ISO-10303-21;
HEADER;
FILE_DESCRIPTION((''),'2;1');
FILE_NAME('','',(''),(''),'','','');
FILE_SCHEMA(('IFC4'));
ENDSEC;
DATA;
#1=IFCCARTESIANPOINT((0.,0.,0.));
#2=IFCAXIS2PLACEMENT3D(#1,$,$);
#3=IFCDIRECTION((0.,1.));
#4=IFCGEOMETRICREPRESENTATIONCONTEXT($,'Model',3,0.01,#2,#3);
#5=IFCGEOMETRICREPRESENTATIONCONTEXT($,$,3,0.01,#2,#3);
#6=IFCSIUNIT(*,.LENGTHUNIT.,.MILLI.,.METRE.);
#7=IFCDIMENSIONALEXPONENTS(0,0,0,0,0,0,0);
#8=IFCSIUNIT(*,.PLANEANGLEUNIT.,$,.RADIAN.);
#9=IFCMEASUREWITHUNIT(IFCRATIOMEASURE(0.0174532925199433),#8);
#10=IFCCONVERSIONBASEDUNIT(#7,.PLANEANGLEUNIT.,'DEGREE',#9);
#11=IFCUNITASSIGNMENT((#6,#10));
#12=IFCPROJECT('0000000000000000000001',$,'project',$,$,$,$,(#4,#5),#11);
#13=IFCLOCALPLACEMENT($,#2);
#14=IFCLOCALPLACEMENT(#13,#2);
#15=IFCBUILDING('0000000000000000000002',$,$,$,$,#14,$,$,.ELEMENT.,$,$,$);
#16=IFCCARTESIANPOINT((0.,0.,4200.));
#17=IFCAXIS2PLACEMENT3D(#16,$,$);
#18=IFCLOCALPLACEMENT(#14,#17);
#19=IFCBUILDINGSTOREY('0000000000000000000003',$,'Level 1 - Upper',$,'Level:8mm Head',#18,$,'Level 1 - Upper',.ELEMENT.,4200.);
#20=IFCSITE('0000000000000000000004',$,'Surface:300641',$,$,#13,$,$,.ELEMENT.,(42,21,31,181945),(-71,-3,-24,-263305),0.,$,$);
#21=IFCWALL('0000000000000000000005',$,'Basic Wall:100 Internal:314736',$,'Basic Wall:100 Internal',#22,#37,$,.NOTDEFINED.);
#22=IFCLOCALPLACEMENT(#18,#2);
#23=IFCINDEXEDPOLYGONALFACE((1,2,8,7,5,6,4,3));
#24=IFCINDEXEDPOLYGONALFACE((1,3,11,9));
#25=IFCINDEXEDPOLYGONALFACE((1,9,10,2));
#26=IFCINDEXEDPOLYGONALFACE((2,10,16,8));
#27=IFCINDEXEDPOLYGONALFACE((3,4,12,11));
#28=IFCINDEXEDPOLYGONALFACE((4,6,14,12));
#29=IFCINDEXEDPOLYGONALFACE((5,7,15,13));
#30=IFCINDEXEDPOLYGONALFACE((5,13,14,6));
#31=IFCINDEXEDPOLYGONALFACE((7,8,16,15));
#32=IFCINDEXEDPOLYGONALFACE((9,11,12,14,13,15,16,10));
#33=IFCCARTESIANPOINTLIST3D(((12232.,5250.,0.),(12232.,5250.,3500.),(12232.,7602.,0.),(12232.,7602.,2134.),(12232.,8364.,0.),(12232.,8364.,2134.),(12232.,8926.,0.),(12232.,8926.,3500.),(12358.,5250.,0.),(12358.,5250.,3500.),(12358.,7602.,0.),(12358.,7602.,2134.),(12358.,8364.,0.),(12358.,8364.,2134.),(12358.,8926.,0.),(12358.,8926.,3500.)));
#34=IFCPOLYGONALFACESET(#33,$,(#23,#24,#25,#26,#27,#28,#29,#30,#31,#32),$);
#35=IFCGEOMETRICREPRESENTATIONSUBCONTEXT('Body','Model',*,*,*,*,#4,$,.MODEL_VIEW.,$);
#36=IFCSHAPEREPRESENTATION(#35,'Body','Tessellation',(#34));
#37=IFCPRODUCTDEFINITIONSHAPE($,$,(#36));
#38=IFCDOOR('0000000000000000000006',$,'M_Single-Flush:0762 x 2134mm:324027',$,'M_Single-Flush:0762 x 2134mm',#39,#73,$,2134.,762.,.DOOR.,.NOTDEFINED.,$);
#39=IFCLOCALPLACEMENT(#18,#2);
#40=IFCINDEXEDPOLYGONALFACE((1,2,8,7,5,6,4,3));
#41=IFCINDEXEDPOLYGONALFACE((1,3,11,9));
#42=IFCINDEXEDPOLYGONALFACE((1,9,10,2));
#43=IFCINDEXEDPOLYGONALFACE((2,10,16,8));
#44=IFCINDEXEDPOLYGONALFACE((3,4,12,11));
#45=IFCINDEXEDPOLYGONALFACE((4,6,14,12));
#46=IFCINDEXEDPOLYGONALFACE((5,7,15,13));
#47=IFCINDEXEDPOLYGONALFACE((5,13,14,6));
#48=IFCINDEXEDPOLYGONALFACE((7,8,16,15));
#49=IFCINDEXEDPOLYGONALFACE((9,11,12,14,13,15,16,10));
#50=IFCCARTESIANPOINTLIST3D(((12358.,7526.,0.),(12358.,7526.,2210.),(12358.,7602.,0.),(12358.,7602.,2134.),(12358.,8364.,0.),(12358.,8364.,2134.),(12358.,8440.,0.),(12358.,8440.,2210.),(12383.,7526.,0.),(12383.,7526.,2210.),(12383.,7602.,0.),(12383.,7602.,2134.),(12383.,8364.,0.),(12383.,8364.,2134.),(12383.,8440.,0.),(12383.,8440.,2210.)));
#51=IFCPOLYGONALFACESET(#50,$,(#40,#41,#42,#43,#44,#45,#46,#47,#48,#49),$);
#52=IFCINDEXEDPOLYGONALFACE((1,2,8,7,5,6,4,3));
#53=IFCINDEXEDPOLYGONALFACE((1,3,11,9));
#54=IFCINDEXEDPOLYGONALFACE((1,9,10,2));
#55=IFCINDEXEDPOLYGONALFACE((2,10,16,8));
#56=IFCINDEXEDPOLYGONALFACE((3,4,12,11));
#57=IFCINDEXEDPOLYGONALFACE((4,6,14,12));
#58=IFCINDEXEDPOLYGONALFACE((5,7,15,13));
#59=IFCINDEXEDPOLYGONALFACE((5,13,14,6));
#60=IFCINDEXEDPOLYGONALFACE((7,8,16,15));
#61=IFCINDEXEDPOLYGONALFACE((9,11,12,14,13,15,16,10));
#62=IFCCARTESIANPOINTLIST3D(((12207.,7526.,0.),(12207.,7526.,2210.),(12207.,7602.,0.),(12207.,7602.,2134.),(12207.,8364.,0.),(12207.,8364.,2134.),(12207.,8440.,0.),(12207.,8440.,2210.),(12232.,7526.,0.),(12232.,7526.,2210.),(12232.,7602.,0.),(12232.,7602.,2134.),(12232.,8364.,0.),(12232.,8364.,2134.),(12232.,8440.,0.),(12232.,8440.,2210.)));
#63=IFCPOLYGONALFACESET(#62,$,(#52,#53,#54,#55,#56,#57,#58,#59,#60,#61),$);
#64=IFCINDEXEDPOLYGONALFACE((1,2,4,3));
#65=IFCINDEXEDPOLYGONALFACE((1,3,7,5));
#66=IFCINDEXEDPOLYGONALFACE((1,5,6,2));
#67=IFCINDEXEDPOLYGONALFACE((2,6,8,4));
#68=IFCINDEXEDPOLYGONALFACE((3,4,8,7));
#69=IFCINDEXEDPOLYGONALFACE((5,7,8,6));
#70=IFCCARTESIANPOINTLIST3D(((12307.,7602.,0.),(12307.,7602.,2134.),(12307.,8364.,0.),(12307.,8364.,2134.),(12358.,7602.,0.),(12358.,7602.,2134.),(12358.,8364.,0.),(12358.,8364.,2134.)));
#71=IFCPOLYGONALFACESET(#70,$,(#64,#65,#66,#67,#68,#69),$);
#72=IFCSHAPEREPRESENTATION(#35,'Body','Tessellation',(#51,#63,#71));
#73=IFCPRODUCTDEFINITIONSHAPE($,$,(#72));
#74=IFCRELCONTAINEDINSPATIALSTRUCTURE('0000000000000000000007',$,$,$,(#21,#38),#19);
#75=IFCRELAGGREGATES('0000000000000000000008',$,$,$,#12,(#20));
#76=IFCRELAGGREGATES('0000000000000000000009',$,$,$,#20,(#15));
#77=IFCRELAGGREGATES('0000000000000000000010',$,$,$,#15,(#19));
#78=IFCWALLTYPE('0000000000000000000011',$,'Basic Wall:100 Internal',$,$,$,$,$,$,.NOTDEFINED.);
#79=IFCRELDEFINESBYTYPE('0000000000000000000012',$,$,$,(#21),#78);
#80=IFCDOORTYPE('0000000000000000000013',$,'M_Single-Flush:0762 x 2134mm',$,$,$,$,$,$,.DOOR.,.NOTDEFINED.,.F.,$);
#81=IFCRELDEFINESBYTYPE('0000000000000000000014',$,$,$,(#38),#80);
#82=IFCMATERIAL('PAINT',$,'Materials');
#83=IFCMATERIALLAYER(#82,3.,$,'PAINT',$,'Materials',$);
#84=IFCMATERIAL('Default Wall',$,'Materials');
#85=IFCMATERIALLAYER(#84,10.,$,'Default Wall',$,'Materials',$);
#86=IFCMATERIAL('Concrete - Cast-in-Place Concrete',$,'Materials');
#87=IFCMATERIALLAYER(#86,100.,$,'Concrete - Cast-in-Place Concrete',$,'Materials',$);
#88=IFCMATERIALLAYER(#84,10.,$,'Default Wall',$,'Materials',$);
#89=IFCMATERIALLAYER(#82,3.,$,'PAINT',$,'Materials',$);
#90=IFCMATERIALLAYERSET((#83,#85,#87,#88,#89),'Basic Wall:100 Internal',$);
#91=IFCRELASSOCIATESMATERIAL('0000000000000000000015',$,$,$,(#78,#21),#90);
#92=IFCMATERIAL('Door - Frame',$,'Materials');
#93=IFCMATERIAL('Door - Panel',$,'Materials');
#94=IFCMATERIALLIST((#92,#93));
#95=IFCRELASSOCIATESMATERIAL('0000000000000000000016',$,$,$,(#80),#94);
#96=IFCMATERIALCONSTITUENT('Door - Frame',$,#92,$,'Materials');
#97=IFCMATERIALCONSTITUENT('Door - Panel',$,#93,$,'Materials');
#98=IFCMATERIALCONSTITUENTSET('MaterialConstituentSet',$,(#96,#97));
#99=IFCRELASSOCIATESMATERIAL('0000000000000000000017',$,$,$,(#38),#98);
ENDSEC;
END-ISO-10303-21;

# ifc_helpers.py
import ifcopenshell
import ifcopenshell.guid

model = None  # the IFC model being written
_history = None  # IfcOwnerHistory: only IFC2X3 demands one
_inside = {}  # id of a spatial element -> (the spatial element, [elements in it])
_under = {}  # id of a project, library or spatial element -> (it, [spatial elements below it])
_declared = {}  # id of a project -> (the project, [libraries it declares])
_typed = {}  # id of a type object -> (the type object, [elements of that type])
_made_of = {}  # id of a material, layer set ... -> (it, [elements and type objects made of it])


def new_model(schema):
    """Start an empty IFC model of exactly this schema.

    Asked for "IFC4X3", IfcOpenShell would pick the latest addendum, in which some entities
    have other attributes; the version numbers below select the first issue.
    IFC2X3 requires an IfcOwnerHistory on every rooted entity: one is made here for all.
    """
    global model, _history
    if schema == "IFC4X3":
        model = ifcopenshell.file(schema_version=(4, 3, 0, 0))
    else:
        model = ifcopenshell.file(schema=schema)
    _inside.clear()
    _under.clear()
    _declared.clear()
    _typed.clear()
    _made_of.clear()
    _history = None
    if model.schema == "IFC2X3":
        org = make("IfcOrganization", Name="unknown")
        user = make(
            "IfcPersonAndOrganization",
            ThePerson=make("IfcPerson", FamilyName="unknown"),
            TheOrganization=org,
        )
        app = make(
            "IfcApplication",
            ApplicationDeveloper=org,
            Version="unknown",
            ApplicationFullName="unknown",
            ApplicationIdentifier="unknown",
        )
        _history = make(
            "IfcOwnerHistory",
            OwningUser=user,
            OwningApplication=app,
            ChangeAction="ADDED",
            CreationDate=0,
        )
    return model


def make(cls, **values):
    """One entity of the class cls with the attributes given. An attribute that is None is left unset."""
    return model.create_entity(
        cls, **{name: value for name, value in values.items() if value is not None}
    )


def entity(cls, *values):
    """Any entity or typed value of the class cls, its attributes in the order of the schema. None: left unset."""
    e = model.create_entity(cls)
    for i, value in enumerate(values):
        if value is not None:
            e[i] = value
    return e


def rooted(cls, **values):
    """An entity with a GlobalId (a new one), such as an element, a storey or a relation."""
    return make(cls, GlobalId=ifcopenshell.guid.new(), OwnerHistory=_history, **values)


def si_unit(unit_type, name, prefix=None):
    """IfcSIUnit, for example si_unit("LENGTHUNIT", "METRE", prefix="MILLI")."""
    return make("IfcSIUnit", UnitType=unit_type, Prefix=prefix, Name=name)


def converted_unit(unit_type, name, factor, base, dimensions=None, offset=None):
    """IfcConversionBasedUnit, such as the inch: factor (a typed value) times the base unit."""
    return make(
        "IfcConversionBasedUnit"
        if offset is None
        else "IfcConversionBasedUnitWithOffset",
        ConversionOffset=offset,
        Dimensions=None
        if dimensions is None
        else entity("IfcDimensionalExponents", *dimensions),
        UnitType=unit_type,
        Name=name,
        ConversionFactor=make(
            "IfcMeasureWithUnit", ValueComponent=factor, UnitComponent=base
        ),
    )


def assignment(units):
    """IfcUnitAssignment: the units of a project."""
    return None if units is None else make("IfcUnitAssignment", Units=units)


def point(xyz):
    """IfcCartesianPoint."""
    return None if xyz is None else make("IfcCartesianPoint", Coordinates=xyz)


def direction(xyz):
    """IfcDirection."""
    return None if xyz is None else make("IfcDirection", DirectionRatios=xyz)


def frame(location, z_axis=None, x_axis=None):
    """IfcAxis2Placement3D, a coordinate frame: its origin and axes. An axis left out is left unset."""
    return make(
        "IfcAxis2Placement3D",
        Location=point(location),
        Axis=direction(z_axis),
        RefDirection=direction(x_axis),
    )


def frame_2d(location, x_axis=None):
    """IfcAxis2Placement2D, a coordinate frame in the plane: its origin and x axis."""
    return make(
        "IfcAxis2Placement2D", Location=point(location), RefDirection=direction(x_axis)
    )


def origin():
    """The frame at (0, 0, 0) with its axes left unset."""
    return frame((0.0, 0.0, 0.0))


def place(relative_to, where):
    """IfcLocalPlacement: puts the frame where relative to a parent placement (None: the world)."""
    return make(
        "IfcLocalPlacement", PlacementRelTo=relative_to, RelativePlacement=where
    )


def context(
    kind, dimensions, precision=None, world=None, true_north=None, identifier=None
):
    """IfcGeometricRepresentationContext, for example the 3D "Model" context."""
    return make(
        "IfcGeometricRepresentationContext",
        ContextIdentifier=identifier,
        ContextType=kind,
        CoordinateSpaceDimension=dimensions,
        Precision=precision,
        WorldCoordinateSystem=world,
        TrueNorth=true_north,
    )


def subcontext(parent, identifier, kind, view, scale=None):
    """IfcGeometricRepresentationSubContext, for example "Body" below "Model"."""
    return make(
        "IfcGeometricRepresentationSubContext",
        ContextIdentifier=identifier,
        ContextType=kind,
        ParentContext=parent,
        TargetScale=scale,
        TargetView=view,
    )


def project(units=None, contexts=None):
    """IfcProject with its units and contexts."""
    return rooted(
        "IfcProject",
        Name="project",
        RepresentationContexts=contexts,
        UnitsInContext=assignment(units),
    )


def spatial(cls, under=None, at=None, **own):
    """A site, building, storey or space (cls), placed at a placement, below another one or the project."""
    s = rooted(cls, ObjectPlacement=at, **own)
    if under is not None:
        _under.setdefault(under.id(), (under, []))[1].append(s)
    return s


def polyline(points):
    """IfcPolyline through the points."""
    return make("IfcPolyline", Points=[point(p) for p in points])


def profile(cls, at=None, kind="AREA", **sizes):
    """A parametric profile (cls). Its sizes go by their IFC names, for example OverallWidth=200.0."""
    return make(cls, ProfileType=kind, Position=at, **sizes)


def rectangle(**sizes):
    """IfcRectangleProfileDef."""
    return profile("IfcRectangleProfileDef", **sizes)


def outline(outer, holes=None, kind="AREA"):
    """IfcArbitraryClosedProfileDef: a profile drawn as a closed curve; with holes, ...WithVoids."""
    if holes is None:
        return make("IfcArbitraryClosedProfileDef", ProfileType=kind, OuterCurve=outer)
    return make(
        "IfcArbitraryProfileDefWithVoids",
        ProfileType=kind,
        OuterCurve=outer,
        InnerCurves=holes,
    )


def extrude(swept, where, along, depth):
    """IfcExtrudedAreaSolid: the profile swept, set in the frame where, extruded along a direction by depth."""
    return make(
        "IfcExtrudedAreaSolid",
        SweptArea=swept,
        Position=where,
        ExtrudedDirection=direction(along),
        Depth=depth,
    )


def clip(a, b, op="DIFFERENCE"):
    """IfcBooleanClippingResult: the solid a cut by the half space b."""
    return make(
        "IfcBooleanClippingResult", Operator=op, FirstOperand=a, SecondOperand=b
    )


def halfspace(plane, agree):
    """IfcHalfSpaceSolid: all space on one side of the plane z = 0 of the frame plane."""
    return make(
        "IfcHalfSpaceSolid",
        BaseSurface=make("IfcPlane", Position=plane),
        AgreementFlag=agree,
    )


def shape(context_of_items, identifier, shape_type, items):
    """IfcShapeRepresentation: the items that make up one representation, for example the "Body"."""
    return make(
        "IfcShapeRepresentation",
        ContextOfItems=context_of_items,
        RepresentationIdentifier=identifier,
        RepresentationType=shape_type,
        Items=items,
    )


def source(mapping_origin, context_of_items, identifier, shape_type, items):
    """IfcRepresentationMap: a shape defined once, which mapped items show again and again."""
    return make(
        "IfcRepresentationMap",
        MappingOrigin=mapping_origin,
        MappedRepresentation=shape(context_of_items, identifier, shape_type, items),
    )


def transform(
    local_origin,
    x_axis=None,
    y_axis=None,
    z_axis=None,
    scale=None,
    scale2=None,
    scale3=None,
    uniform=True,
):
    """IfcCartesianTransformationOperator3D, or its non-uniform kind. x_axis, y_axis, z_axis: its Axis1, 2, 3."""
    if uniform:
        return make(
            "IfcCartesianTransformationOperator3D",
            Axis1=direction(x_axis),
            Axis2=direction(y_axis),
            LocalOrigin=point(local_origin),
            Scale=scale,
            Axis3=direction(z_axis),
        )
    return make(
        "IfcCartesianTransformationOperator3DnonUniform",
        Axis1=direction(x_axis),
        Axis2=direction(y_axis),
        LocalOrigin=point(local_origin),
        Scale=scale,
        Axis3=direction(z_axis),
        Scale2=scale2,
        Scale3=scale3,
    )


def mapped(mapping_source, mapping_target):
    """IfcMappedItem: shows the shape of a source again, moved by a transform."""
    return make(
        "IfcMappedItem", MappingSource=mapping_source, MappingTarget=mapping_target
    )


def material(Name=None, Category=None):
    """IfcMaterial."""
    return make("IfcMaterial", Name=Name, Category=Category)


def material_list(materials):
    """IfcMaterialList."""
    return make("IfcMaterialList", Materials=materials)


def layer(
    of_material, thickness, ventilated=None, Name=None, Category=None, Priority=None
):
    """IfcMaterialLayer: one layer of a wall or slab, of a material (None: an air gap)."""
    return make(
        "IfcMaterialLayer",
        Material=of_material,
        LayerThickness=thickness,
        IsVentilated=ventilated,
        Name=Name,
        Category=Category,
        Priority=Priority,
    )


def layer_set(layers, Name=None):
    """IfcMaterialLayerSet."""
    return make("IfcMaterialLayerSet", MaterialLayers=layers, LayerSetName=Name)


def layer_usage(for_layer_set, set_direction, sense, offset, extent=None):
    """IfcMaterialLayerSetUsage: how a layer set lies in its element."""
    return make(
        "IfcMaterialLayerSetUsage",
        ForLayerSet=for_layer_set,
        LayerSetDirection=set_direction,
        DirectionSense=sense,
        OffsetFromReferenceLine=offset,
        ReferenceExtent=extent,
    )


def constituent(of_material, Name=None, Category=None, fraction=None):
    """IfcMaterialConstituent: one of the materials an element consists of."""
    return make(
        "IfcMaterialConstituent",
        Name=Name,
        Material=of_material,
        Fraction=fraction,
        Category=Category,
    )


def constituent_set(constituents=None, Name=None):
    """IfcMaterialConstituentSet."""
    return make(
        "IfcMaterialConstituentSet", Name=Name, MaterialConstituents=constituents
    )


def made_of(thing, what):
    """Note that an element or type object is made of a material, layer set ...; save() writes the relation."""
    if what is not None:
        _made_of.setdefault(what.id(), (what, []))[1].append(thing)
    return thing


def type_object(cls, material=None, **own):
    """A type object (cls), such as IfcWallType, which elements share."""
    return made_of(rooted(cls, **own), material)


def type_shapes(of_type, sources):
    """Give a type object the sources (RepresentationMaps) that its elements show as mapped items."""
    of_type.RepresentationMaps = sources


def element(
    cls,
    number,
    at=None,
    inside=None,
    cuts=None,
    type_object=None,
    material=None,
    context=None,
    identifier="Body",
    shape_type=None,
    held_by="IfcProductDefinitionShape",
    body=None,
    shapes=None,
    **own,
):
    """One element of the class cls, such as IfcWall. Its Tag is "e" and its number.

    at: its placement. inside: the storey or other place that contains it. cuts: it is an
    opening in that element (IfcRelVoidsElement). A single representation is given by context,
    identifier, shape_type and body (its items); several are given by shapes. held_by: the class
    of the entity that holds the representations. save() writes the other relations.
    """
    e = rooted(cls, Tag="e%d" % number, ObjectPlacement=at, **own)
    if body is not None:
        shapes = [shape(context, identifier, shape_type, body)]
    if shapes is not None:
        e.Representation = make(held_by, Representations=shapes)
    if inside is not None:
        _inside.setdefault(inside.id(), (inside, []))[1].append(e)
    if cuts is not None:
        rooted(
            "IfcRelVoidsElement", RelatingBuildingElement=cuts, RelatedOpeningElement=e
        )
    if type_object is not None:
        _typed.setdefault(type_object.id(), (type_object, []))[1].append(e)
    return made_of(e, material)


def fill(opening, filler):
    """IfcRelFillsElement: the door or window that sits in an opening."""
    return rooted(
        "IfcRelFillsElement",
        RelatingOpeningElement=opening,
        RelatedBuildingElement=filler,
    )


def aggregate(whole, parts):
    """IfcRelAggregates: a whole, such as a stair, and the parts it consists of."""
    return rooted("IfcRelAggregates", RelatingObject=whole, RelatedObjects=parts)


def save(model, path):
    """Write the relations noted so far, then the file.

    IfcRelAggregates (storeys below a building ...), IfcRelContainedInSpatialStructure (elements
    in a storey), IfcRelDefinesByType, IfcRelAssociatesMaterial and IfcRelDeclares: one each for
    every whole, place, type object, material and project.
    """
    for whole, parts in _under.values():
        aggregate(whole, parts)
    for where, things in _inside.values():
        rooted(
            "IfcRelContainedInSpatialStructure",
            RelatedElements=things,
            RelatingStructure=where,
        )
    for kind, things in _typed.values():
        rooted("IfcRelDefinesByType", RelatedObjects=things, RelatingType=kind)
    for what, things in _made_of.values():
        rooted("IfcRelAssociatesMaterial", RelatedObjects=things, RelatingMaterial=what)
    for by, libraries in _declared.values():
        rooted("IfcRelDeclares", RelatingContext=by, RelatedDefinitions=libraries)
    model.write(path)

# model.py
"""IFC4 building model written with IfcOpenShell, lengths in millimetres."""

from ifc_helpers import new_model, entity, si_unit, converted_unit, direction, frame, frame_2d, origin, place, context, subcontext, project, spatial, polyline, rectangle, outline, extrude, clip, halfspace, source, transform, mapped, material, material_list, layer, layer_set, layer_usage, constituent, constituent_set, type_object, type_shapes, element, fill, save


model = new_model("IFC4")

# Units and contexts
model_context = context("Model", 3, precision=0.01, world=origin(), true_north=direction((0.0, 1.0)))
context_of_model = context(None, 3, precision=0.01, world=origin(), true_north=direction((0.0, 1.0)))
body_context = subcontext(model_context, "Body", "Model", "MODEL_VIEW")
ifc_project = project(units=[si_unit("LENGTHUNIT", "METRE", prefix="MILLI"), converted_unit("PLANEANGLEUNIT", "DEGREE", entity("IfcRatioMeasure", 0.0174532925199433), si_unit("PLANEANGLEUNIT", "RADIAN"), dimensions=[0, 0, 0, 0, 0, 0, 0])], contexts=[model_context, context_of_model])

# Site, building, storey
site_placement = place(None, origin())
site = spatial("IfcSite", under=ifc_project, at=site_placement, Name="Surface:300641", CompositionType="ELEMENT", RefLatitude=(42, 21, 31, 181945), RefLongitude=(-71, -3, -24, -263305), RefElevation=0.0)
building_placement = place(site_placement, origin())
building = spatial("IfcBuilding", under=site, at=building_placement, CompositionType="ELEMENT")
storey_placement = place(building_placement, frame((0.0, 0.0, 4200.0)))
storey = spatial("IfcBuildingStorey", under=building, at=storey_placement, Name="Level 1 - Upper", ObjectType="Level:8mm Head", LongName="Level 1 - Upper", CompositionType="ELEMENT", Elevation=4200.0)

# Shared definitions
ifc_material_1 = material(Name="Concrete - Cast-in-Place Concrete", Category="Materials")

# Shared definitions
ifc_material_2 = material(Name="PAINT", Category="Materials")
ifc_material_3 = material(Name="Default Wall", Category="Materials")

# Wall, opening, door
ifc_layer_1 = layer(ifc_material_2, 3.0, Name="PAINT", Category="Materials")
ifc_layer_2 = layer(ifc_material_3, 10.0, Name="Default Wall", Category="Materials")
ifc_layer_3 = layer(ifc_material_1, 100.0, Name="Concrete - Cast-in-Place Concrete", Category="Materials")
ifc_layer_4 = layer(ifc_material_3, 10.0, Name="Default Wall", Category="Materials")
ifc_layer_5 = layer(ifc_material_2, 3.0, Name="PAINT", Category="Materials")
ifc_layer_set_1 = layer_set([ifc_layer_1, ifc_layer_2, ifc_layer_3, ifc_layer_4, ifc_layer_5], Name="Basic Wall:100 Internal")
ifc_layer_usage_1 = layer_usage(ifc_layer_set_1, "AXIS2", "NEGATIVE", 63.0)
wall_type_1 = type_object("IfcWallType", Name="Basic Wall:100 Internal", PredefinedType="NOTDEFINED", material=ifc_layer_set_1)
wall_1_placement = place(storey_placement, frame((12295.0, 5250.0, 0.0), z_axis=(0.0, 0.0, 1.0), x_axis=(0.0, 1.0, 0.0)))
wall_1 = element("IfcWall", 1, at=wall_1_placement, inside=storey, type_object=wall_type_1, material=ifc_layer_usage_1, Name="Basic Wall:100 Internal:314736", ObjectType="Basic Wall:100 Internal", PredefinedType="NOTDEFINED", context=body_context, shape_type="Clipping", body=[
    clip(extrude(rectangle(XDim=3676.0, YDim=126.0, at=frame_2d((1838.0, 0.0), x_axis=(-1.0, 0.0))), origin(), (0.0, 0.0, 1.0), 3500.0), halfspace(origin(), True)),
])
opening_1_placement = place(wall_1_placement, frame((3114.0, 63.0, 0.0)))
opening_1 = element("IfcOpeningElement", 2, at=opening_1_placement, cuts=wall_1, ObjectType="Opening", PredefinedType="OPENING", context=body_context, shape_type="SweptSolid", body=[
    extrude(rectangle(XDim=762.0, YDim=2134.0, at=frame_2d((1067.0, 381.0), x_axis=(0.0, -1.0))), frame((0.0, 0.0, 0.0), z_axis=(0.0, -1.0, 0.0), x_axis=(0.0, 0.0, 1.0)), (0.0, 0.0, 1.0), 126.0),
])
ifc_material_4 = material(Name="Door - Frame", Category="Materials")
ifc_constituent_1 = constituent(ifc_material_4, Name="Door - Frame", Category="Materials")
ifc_material_5 = material(Name="Door - Panel", Category="Materials")
ifc_constituent_2 = constituent(ifc_material_5, Name="Door - Panel", Category="Materials")
ifc_constituent_set = constituent_set(constituents=[ifc_constituent_1, ifc_constituent_2], Name="MaterialConstituentSet")
ifc_material_list = material_list([ifc_material_4, ifc_material_5])
door_type = type_object("IfcDoorType", Name="M_Single-Flush:0762 x 2134mm", OperationType="NOTDEFINED", ParameterTakesPrecedence=False, PredefinedType="DOOR", material=ifc_material_list)
shared_shape_1 = source(origin(), body_context, "Body", "SweptSolid", [
    extrude(outline(polyline([(-457.0, -1124.0), (457.0, -1124.0), (457.0, 1086.0), (381.0, 1086.0), (381.0, -1048.0), (-381.0, -1048.0), (-381.0, 1086.0), (-457.0, 1086.0), (-457.0, -1124.0)])), frame((381.0, 151.0, 1086.0), z_axis=(0.0, -1.0, 0.0), x_axis=(-1.0, 0.0, 0.0)), (0.0, 0.0, 1.0), 25.0),
    extrude(outline(polyline([(-1124.0, -457.0), (1086.0, -457.0), (1086.0, -381.0), (-1048.0, -381.0), (-1048.0, 381.0), (1086.0, 381.0), (1086.0, 457.0), (-1124.0, 457.0), (-1124.0, -457.0)])), frame((381.0, 0.0, 1086.0), z_axis=(0.0, -1.0, 0.0), x_axis=(0.0, 0.0, -1.0)), (0.0, 0.0, 1.0), 25.0),
    extrude(rectangle(XDim=762.0, YDim=51.0, at=frame_2d((0.0, 0.0), x_axis=(1.0, 0.0))), frame((381.0, 100.5, 0.0)), (0.0, 0.0, 1.0), 2134.0),
])
type_shapes(door_type, [shared_shape_1])
door_placement = place(opening_1_placement, frame((0.0, 0.0, 0.0), z_axis=(0.0, 0.0, 1.0), x_axis=(-1.0, 0.0, 0.0)))
door = element("IfcDoor", 3, at=door_placement, inside=storey, type_object=door_type, material=ifc_constituent_set, Name="M_Single-Flush:0762 x 2134mm:324027", ObjectType="M_Single-Flush:0762 x 2134mm", OperationType="NOTDEFINED", OverallHeight=2134.0, OverallWidth=762.0, PredefinedType="DOOR", context=body_context, shape_type="MappedRepresentation", body=[
    mapped(shared_shape_1, transform((0.0, 0.0, 0.0), scale=1.0)),
])
fill(opening_1, door)

save(model, "model.ifc")
